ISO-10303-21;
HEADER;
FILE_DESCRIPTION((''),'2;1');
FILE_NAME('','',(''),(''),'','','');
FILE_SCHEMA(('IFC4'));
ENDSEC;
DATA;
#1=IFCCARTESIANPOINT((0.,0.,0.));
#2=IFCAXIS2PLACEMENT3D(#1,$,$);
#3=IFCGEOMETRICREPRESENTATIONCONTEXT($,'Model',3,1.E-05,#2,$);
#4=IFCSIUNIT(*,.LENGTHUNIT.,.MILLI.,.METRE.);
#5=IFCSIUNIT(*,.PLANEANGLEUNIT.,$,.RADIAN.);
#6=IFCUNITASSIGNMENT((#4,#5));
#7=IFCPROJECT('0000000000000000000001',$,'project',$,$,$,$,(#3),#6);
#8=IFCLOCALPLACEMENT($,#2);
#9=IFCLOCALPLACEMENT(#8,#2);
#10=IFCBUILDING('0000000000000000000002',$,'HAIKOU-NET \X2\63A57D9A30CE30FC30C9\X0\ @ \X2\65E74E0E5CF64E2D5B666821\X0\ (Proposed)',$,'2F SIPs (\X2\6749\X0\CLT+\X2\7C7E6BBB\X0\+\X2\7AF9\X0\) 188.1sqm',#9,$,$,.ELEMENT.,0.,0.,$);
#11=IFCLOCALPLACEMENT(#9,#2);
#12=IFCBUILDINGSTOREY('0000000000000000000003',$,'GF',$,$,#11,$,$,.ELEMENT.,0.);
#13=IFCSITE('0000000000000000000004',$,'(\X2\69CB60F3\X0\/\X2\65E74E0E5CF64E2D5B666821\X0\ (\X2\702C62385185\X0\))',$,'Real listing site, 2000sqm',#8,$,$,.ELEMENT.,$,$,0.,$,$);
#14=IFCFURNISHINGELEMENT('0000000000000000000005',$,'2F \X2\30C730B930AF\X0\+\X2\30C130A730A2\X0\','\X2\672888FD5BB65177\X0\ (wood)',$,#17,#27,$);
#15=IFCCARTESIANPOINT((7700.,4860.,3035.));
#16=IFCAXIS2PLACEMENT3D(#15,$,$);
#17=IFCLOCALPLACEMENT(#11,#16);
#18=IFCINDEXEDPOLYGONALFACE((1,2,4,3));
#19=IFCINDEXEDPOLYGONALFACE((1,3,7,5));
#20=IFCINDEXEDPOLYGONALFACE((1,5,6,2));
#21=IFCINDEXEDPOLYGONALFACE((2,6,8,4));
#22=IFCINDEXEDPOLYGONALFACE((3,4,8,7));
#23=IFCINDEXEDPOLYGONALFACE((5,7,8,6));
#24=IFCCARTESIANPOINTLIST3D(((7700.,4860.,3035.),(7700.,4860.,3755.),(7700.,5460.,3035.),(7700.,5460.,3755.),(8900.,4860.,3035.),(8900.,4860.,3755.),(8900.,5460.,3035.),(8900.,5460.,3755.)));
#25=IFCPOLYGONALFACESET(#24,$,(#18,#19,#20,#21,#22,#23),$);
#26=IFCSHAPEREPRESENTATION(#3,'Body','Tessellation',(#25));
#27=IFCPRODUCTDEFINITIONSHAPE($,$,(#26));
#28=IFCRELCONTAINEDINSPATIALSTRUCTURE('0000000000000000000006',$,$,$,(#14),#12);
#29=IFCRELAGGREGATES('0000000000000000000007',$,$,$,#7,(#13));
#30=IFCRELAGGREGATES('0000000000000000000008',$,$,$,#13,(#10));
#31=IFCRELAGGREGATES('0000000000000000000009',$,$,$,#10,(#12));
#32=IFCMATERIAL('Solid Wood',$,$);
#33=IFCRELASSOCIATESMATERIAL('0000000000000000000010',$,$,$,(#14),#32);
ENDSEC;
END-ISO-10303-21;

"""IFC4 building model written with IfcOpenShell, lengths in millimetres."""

from ifc_helpers import new_model, si_unit, frame, frame_2d, origin, place, context, project, spatial, rectangle, extrude, material, element, save


model = new_model("IFC4")

# Units and contexts
model_context = context("Model", 3, precision=1e-05, world=origin())
ifc_project = project(units=[si_unit("LENGTHUNIT", "METRE", prefix="MILLI"), si_unit("PLANEANGLEUNIT", "RADIAN")], contexts=[model_context])

# Site, building, storey
site_placement = place(None, origin())
site = spatial("IfcSite", under=ifc_project, at=site_placement, Name="(構想/旧与島中学校 (瀬戸内))", ObjectType="Real listing site, 2000sqm", CompositionType="ELEMENT", RefElevation=0.0)
building_placement = place(site_placement, origin())
building = spatial("IfcBuilding", under=site, at=building_placement, Name="HAIKOU-NET 接続ノード @ 旧与島中学校 (Proposed)", ObjectType="2F SIPs (杉CLT+籾殻+竹) 188.1sqm", CompositionType="ELEMENT", ElevationOfRefHeight=0.0, ElevationOfTerrain=0.0)
storey_placement = place(building_placement, origin())
storey = spatial("IfcBuildingStorey", under=building, at=storey_placement, Name="GF", CompositionType="ELEMENT", Elevation=0.0)

# Shared definitions
ifc_material_1 = material(Name="Solid Wood")

# Furnishing element
furnishing_1_placement = place(storey_placement, frame((7700.0, 4860.0, 3035.0)))
element("IfcFurnishingElement", 1, at=furnishing_1_placement, inside=storey, material=ifc_material_1, Name="2F デスク+チェア", Description="木製家具 (wood)", context=model_context, shape_type="SweptSolid", body=[
    extrude(rectangle(XDim=1200.0, YDim=600.0, at=frame_2d((600.0, 300.0))), frame((7700.0, 4860.0, 3035.0)), (0.0, 0.0, 1.0), 720.0),
])

save(model, "model.ifc")
